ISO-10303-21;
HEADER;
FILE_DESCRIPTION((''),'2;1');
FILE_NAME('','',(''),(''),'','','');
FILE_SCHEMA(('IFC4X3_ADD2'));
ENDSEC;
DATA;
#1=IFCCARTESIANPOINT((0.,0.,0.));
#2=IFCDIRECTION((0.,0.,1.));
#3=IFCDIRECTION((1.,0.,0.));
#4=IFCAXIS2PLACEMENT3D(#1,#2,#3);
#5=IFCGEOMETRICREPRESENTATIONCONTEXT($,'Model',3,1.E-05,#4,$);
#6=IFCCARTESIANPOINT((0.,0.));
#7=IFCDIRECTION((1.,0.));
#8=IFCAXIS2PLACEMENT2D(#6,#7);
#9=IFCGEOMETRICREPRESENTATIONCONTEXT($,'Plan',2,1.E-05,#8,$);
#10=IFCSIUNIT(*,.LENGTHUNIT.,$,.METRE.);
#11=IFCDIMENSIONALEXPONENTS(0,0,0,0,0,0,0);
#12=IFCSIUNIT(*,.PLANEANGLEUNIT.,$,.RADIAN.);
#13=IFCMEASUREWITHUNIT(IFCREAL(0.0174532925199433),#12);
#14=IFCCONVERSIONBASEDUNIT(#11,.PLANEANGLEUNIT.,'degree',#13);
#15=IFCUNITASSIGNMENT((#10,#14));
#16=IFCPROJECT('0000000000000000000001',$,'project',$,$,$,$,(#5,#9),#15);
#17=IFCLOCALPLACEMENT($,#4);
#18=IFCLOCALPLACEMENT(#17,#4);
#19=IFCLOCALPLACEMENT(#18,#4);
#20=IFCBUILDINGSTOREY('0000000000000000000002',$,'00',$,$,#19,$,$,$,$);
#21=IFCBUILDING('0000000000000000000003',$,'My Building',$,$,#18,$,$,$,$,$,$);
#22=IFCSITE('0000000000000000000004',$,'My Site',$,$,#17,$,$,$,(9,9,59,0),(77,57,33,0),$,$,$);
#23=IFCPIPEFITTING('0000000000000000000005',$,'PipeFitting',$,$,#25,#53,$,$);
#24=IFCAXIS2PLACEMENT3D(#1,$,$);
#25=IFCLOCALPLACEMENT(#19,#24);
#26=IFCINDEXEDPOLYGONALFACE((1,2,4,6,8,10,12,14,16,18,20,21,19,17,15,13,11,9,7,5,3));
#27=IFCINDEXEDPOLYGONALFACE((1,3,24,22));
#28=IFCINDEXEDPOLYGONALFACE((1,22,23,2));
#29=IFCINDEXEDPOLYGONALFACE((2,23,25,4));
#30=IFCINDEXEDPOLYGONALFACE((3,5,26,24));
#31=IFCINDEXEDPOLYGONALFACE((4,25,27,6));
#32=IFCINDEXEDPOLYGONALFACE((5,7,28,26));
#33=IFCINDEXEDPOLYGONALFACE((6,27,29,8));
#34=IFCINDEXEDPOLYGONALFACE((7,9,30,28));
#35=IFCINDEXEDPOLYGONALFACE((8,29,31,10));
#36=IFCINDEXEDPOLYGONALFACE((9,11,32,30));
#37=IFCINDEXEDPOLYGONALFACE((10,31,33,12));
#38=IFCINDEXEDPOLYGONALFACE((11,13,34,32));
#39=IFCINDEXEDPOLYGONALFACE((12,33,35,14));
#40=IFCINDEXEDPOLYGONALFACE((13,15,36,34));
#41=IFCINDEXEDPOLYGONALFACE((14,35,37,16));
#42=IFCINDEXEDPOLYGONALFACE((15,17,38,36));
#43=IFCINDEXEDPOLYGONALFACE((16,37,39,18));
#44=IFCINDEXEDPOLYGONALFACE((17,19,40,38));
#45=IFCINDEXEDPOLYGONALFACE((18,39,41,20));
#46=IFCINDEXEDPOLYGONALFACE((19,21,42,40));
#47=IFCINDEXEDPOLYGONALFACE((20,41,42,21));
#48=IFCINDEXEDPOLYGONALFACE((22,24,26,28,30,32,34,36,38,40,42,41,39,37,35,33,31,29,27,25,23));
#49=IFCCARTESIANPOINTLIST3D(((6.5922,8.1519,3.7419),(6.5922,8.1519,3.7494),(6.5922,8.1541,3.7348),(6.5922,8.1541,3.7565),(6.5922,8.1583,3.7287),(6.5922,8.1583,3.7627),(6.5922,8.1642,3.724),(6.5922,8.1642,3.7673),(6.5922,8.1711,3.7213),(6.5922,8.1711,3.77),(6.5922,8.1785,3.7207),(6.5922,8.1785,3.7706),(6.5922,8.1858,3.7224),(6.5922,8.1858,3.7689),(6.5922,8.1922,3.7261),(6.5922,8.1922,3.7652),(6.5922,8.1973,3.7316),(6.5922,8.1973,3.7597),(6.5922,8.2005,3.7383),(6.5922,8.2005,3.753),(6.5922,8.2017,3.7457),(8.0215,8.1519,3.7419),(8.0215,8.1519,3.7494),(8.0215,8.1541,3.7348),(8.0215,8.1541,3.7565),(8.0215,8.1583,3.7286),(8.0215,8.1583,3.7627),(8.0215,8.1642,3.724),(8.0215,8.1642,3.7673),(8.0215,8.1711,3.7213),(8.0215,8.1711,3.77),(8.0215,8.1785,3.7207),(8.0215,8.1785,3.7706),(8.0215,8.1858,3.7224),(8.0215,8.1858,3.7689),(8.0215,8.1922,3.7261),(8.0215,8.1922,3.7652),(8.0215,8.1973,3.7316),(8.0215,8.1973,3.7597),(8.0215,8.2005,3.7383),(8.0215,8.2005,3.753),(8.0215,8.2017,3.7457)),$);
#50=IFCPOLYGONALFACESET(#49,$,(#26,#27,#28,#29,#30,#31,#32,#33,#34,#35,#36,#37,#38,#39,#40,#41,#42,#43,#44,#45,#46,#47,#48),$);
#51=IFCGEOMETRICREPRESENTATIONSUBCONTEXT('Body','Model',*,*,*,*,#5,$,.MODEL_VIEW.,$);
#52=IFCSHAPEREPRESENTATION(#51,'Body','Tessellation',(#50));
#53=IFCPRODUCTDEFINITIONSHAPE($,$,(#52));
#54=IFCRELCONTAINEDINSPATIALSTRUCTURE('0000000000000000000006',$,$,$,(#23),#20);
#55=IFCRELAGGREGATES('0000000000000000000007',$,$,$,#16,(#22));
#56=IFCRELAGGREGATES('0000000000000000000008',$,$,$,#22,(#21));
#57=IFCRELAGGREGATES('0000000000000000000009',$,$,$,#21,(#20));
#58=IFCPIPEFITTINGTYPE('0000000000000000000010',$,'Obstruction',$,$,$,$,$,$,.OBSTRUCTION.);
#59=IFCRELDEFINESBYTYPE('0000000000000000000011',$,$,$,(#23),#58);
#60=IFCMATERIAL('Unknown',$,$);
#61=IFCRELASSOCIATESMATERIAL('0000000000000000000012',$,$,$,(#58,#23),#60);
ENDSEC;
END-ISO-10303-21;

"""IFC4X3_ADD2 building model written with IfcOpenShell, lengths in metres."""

from ifc_helpers import new_model, entity, si_unit, converted_unit, frame, origin_with_axes, origin_2d_with_axis, place, context, subcontext, project, spatial, circle, extrude, material, material_profile, profile_set, profile_usage, type_object, element, save


model = new_model("IFC4X3_ADD2")

# Units and contexts
model_context = context("Model", 3, precision=1e-05, world=origin_with_axes())
plan_context = context("Plan", 2, precision=1e-05, world=origin_2d_with_axis())
body_context = subcontext(model_context, "Body", "Model", "MODEL_VIEW")
ifc_project = project(units=[si_unit("LENGTHUNIT", "METRE"), converted_unit("PLANEANGLEUNIT", "degree", entity("IfcReal", 0.0174532925199433), si_unit("PLANEANGLEUNIT", "RADIAN"), dimensions=[0, 0, 0, 0, 0, 0, 0])], contexts=[model_context, plan_context])

# Site, building, storey
site_placement = place(None, origin_with_axes())
site = spatial("IfcSite", under=ifc_project, at=site_placement, Name="My Site", RefLatitude=(9, 9, 59, 0), RefLongitude=(77, 57, 33, 0))
building_placement = place(site_placement, origin_with_axes())
building = spatial("IfcBuilding", under=site, at=building_placement, Name="My Building")
storey_placement = place(building_placement, origin_with_axes())
storey = spatial("IfcBuildingStorey", under=building, at=storey_placement, Name="00")

# Shared definitions
ifc_material_1 = material(Name="Unknown")

# Pipe fitting
ifc_material_profile_1 = material_profile(ifc_material_1, circle(Radius=0.025))
ifc_profile_set_1 = profile_set([ifc_material_profile_1])
ifc_profile_usage_1 = profile_usage(ifc_profile_set_1, cardinal=5)
pipe_fitting_type = type_object("IfcPipeFittingType", Name="Obstruction", PredefinedType="OBSTRUCTION", material=ifc_profile_set_1)
pipe_fitting_placement = place(storey_placement, frame((6.5922, 8.1767, 3.7457), z_axis=(1.0, 0.0, 0.0), x_axis=(0.0, 1.0, 0.0)))
element("IfcPipeFitting", 1, at=pipe_fitting_placement, inside=storey, type_object=pipe_fitting_type, material=ifc_profile_usage_1, Name="PipeFitting", context=body_context, shape_type="SweptSolid", body=[
    extrude(circle(Radius=0.025), origin_with_axes(), (0.0, 0.0, 1.0), 1.4294),
])

save(model, "model.ifc")
